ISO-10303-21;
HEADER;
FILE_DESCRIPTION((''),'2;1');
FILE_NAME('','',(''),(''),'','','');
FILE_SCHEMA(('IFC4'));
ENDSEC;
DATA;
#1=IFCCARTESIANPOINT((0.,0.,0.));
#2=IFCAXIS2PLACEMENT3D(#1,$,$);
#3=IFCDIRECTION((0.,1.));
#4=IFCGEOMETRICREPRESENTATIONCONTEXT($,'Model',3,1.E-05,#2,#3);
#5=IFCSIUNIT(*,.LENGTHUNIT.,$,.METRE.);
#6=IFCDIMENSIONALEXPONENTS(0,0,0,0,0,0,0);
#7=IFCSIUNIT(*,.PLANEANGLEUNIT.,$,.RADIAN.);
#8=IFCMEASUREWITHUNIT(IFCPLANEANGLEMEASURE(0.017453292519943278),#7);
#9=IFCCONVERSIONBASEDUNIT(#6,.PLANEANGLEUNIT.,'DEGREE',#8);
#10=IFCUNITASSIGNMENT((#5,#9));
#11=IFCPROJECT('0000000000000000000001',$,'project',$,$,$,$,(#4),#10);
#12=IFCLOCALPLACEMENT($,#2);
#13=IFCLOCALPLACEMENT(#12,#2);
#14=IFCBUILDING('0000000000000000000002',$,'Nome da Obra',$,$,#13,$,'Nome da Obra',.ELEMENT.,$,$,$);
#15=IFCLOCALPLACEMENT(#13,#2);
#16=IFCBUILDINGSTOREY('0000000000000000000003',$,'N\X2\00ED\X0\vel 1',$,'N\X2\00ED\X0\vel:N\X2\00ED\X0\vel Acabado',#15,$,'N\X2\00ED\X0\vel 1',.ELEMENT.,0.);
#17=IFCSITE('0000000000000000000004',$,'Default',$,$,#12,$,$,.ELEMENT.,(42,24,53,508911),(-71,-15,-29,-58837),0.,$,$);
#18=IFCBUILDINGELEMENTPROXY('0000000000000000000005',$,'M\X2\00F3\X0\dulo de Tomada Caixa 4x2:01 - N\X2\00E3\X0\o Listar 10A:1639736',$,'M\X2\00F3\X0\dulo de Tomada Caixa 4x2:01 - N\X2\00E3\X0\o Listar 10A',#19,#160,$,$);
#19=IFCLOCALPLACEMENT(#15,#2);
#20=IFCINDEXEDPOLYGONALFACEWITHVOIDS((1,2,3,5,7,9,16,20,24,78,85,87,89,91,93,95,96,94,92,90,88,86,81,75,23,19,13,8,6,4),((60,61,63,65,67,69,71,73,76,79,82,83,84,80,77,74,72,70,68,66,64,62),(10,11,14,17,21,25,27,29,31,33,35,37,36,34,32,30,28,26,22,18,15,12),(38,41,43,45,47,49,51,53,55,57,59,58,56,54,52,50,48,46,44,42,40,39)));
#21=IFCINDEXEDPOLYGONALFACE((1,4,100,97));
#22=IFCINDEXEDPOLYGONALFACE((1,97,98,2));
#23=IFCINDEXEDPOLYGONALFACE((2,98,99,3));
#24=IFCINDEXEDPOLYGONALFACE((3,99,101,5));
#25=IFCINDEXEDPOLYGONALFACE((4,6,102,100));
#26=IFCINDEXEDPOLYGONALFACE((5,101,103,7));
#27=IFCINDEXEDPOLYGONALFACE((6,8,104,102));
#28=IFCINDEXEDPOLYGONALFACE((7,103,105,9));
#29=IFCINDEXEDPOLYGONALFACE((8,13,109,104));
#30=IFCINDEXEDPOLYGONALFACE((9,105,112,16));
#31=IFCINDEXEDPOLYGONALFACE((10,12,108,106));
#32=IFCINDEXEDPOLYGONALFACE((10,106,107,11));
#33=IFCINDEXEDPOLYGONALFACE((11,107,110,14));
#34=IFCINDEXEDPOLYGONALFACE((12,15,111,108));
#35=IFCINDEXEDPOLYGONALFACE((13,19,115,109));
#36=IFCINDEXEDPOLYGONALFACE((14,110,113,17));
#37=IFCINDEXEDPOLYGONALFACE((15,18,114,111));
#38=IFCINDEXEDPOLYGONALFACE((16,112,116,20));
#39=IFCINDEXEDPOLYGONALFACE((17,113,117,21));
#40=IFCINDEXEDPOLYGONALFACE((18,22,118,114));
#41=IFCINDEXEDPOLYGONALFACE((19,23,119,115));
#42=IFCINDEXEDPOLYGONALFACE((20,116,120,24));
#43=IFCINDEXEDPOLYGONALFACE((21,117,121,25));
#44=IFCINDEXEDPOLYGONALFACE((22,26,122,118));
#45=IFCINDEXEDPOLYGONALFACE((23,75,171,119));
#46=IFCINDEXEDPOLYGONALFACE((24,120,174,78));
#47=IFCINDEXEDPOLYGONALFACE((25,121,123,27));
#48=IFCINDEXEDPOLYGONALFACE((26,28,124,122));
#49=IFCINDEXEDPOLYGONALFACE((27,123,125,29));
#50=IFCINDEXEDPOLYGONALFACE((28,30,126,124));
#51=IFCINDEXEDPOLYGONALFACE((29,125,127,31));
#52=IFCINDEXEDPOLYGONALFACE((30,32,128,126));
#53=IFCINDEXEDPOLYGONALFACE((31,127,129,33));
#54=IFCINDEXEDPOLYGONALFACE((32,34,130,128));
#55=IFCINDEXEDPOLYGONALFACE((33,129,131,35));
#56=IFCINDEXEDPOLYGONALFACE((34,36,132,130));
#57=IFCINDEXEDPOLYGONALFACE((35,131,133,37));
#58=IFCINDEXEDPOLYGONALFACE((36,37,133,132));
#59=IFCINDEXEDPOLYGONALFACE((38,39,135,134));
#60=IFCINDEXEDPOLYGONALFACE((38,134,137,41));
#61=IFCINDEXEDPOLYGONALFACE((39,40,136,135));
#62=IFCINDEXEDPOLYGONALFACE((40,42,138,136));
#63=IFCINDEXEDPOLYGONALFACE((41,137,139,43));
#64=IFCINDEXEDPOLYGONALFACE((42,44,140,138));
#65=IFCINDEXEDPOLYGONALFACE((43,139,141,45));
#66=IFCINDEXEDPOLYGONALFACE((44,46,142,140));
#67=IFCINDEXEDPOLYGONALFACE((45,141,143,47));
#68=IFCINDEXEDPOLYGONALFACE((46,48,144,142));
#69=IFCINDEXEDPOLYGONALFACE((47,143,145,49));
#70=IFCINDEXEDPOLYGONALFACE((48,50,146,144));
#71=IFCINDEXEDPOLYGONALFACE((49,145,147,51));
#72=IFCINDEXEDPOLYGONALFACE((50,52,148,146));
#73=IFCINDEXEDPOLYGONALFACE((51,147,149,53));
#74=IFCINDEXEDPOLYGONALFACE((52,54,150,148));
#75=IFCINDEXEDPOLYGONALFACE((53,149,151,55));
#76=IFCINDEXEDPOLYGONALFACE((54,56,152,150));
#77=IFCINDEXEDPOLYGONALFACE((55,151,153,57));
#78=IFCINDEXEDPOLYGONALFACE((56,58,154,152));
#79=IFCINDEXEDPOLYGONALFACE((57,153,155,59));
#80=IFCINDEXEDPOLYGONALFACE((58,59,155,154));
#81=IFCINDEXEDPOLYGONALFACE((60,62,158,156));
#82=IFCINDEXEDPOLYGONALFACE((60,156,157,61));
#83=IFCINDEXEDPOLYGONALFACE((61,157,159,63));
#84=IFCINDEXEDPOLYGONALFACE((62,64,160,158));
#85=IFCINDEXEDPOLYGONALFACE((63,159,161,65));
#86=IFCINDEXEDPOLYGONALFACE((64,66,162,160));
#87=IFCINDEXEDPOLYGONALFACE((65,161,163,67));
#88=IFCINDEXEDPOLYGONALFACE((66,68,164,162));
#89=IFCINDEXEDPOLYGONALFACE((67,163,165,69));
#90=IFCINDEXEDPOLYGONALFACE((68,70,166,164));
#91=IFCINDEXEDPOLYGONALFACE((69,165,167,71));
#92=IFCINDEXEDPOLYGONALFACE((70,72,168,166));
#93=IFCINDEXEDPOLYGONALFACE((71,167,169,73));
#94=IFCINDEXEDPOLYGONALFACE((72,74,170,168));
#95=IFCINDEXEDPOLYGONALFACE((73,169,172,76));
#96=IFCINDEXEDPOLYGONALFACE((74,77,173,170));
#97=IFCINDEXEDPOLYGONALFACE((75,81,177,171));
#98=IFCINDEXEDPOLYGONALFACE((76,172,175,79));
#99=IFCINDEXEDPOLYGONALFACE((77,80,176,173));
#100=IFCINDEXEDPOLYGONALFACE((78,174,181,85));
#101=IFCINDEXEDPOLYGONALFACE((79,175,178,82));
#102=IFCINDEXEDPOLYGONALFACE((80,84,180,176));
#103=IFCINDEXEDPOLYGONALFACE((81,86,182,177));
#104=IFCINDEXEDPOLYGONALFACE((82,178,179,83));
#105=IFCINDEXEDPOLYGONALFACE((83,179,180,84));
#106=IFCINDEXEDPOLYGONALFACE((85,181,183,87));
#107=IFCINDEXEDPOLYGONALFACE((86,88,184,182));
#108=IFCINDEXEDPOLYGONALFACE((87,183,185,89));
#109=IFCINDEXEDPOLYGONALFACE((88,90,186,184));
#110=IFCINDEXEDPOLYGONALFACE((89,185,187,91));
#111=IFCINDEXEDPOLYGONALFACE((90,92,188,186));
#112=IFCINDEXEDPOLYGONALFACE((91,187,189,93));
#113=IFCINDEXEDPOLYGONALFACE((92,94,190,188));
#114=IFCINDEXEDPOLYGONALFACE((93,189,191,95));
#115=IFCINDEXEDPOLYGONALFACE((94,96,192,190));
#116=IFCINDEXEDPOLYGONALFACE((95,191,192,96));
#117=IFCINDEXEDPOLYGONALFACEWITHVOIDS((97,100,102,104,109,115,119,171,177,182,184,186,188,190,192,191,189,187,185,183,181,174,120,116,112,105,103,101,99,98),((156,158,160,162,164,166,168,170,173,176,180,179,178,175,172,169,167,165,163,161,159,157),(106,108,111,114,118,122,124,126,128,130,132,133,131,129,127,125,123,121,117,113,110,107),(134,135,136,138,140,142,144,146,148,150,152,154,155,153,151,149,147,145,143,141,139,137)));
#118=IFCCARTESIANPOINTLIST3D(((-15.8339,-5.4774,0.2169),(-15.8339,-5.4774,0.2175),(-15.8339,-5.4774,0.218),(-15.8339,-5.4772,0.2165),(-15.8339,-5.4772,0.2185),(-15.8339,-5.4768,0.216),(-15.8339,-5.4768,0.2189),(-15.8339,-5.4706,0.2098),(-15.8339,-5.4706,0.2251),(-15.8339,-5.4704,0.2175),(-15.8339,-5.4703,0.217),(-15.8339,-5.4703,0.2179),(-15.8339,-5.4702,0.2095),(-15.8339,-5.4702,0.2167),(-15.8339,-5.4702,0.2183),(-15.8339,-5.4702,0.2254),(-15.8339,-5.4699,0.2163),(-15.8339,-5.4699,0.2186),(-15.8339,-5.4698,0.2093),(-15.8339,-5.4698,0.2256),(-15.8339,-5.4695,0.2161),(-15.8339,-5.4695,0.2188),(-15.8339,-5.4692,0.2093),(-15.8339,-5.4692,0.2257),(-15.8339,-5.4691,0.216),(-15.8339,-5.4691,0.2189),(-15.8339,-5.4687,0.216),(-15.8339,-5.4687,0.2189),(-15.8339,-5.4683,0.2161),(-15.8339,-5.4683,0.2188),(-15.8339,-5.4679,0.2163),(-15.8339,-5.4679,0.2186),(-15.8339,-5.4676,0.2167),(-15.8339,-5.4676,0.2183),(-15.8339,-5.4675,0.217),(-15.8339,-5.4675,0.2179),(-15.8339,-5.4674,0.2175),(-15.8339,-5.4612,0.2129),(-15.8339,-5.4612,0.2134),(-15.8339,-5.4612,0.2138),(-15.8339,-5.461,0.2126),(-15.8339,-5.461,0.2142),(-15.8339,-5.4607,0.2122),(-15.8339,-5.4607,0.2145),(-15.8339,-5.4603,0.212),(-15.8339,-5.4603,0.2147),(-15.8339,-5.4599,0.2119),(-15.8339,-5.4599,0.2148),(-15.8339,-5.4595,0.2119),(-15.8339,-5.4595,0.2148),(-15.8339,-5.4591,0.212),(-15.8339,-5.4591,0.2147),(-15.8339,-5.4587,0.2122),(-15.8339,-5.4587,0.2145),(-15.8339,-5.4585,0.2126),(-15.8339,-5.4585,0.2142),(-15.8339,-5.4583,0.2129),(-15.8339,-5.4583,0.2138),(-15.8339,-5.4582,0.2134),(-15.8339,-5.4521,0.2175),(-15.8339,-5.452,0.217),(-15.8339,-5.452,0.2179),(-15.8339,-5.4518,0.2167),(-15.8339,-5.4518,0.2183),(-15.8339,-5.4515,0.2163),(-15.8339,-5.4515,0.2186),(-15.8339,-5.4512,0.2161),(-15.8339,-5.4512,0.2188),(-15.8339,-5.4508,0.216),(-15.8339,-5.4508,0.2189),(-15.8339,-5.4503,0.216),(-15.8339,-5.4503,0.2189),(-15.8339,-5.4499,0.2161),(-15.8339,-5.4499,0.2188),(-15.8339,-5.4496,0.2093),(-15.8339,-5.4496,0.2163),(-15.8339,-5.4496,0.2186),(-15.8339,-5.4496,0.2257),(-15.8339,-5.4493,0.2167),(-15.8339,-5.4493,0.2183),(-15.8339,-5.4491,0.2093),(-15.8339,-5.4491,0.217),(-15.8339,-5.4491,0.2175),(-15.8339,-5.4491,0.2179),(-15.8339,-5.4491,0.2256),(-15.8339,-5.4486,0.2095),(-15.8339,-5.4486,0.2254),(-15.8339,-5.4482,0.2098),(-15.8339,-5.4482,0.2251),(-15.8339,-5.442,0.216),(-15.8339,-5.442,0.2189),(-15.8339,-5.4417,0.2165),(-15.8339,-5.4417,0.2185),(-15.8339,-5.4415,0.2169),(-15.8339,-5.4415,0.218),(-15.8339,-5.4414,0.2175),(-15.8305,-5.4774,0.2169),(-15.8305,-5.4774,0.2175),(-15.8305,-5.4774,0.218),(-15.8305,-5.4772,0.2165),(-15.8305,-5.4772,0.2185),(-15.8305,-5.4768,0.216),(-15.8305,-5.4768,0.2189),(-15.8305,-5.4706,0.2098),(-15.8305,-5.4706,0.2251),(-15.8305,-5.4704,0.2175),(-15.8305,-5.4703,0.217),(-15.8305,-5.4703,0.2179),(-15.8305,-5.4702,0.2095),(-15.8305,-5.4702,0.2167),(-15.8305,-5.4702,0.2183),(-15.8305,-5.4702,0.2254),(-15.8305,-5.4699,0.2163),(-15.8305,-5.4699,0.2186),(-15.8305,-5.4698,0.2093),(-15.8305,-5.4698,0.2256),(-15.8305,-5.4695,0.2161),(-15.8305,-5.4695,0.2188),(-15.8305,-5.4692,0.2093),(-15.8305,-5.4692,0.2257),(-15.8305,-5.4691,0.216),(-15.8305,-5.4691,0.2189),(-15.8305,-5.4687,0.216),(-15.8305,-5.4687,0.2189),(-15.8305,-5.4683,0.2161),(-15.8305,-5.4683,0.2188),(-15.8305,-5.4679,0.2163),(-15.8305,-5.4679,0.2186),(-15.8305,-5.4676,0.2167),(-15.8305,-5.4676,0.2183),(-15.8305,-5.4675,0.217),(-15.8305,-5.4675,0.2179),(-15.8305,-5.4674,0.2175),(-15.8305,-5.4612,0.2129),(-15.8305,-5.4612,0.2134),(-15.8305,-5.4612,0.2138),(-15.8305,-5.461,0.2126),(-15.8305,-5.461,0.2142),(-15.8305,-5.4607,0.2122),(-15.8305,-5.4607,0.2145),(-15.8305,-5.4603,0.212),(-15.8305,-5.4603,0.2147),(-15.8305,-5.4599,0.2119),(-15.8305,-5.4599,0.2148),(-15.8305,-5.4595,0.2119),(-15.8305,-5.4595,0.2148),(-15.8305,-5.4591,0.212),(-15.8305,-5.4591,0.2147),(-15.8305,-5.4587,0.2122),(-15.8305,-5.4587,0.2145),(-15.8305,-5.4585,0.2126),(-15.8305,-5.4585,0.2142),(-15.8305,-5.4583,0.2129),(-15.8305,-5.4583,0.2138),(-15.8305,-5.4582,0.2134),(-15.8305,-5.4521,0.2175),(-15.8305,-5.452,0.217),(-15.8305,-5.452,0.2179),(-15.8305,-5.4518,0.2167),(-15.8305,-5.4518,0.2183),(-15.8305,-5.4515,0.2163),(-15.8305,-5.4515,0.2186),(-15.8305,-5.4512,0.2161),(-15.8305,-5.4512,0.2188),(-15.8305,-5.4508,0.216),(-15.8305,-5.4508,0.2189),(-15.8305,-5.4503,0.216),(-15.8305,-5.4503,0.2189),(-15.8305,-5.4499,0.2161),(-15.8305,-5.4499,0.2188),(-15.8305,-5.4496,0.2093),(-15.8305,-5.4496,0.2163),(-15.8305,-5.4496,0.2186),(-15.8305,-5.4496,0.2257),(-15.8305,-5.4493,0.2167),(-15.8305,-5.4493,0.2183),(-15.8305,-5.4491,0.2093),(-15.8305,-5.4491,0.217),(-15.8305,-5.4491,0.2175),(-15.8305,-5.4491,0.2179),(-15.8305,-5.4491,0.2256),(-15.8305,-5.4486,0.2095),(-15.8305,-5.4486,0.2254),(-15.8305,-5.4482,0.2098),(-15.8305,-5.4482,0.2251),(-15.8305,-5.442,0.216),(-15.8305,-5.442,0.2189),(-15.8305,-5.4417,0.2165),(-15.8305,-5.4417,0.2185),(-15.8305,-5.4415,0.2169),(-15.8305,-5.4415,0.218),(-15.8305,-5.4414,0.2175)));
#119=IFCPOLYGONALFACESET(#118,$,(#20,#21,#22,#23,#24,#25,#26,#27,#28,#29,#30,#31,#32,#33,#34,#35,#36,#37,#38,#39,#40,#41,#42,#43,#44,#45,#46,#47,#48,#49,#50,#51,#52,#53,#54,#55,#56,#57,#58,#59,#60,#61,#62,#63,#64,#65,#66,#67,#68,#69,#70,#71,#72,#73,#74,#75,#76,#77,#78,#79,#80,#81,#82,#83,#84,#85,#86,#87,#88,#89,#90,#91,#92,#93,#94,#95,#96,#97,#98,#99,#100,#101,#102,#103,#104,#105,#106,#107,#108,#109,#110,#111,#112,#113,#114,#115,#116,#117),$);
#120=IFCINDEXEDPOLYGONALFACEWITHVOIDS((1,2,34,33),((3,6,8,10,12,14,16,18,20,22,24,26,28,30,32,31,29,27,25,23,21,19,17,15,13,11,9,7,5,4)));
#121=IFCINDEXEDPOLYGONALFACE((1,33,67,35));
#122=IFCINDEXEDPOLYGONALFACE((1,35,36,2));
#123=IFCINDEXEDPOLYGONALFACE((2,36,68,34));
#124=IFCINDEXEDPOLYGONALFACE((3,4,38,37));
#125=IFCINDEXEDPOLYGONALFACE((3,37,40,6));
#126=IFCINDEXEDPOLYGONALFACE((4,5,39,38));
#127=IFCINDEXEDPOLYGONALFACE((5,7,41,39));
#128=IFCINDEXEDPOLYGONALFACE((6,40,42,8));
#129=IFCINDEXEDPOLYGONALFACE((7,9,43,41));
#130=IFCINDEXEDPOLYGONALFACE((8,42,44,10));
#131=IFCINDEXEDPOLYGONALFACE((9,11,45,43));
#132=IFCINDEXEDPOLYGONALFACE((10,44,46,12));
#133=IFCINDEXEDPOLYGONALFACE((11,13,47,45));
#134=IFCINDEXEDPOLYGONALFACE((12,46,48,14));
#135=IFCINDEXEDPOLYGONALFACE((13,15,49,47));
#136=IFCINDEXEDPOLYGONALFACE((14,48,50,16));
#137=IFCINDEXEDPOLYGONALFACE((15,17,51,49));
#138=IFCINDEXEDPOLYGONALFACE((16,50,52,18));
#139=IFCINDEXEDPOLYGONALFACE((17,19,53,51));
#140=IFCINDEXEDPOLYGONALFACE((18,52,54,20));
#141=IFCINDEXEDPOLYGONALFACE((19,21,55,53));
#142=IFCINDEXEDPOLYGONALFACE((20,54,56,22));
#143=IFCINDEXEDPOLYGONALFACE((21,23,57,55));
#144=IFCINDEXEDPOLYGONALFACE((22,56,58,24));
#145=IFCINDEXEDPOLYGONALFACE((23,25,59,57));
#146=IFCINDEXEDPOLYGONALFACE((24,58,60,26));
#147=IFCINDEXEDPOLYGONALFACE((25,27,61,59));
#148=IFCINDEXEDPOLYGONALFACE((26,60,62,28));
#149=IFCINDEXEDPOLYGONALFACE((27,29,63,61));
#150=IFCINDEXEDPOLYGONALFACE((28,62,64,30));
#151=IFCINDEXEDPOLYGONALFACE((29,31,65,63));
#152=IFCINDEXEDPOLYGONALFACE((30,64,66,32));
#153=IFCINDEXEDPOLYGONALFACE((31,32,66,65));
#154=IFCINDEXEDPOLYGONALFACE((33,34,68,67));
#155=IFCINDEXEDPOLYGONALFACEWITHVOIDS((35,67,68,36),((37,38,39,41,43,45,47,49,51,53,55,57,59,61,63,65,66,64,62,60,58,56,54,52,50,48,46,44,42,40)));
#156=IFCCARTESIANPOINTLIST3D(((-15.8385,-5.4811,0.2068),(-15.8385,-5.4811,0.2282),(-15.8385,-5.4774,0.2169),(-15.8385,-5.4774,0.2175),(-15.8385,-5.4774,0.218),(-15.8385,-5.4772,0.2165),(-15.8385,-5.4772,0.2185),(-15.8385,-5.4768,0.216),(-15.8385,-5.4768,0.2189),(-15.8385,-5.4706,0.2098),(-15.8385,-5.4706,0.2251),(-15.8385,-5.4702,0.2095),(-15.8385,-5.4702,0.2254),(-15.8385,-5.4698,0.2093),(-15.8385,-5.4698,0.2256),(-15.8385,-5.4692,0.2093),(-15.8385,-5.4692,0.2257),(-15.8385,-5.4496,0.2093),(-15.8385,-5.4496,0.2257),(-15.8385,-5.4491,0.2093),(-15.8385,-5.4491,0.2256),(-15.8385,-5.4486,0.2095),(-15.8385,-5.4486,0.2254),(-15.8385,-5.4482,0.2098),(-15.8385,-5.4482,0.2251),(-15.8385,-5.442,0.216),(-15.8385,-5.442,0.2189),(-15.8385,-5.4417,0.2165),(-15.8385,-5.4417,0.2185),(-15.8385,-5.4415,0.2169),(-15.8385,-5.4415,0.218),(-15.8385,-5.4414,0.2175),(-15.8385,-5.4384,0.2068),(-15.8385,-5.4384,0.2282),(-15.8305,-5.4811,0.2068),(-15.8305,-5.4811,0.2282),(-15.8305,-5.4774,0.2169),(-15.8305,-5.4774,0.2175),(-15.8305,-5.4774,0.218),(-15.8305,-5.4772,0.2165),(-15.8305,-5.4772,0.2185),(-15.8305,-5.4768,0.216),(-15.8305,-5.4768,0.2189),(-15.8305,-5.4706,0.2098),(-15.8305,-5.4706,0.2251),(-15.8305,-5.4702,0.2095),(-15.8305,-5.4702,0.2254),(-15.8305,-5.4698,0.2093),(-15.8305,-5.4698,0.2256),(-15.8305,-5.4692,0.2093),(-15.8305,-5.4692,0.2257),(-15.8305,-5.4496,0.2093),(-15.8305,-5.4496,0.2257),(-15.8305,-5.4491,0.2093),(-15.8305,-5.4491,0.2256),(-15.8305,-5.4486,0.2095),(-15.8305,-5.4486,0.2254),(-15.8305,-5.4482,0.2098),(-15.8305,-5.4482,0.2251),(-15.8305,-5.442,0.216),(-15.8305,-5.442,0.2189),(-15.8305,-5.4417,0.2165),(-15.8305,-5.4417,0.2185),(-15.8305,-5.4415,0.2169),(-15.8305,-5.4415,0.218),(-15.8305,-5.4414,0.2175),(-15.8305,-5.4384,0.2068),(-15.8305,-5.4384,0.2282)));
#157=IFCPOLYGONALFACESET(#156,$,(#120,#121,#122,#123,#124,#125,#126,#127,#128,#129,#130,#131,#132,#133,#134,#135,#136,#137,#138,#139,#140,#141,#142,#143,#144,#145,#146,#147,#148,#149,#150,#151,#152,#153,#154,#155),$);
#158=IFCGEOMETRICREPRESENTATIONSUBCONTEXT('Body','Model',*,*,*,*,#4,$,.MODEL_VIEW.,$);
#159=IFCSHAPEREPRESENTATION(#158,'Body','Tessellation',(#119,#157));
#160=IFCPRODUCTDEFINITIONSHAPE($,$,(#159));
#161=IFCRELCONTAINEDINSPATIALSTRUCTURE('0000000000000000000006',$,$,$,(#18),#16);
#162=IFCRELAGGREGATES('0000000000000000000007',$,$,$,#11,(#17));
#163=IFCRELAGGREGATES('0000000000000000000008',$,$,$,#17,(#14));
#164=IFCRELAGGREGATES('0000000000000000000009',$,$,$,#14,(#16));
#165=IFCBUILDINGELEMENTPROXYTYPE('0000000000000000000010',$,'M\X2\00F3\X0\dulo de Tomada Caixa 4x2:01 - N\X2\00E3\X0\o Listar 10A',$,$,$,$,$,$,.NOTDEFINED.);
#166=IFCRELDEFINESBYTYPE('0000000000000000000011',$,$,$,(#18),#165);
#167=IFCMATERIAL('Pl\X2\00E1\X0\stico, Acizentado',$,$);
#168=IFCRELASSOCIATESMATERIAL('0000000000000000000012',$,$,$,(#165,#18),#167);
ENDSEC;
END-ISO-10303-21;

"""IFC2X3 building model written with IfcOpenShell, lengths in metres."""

from ifc_helpers import new_model, entity, si_unit, converted_unit, direction, frame, frame_2d, origin, place, context, subcontext, project, spatial, polyline, circle_curve, parameter, trimmed, segment, composite_curve, outline, extrude, source, transform, mapped, material, type_object, type_shapes, element, save


model = new_model("IFC2X3")

# Units and contexts
model_context = context("Model", 3, precision=1e-05, world=origin(), true_north=direction((0.0, 1.0)))
body_context = subcontext(model_context, "Body", "Model", "MODEL_VIEW")
ifc_project = project(units=[si_unit("LENGTHUNIT", "METRE"), converted_unit("PLANEANGLEUNIT", "DEGREE", entity("IfcPlaneAngleMeasure", 0.017453292519943278), si_unit("PLANEANGLEUNIT", "RADIAN"), dimensions=[0, 0, 0, 0, 0, 0, 0])], contexts=[model_context])

# Site, building, storey
site_placement = place(None, origin())
site = spatial("IfcSite", under=ifc_project, at=site_placement, Name="Default", CompositionType="ELEMENT", RefLatitude=(42, 24, 53, 508911), RefLongitude=(-71, -15, -29, -58837), RefElevation=0.0)
building_placement = place(site_placement, origin())
building = spatial("IfcBuilding", under=site, at=building_placement, Name="Nome da Obra", LongName="Nome da Obra", CompositionType="ELEMENT")
storey_placement = place(building_placement, origin())
storey = spatial("IfcBuildingStorey", under=building, at=storey_placement, Name="Nível 1", ObjectType="Nível:Nível Acabado", LongName="Nível 1", CompositionType="ELEMENT", Elevation=0.0)

# Building element proxy
ifc_material_1 = material(Name="Plástico, Acizentado")
building_element_proxy_type_1 = type_object("IfcBuildingElementProxyType", Name="Módulo de Tomada Caixa 4x2:01 - Não Listar 10A", PredefinedType="NOTDEFINED", material=ifc_material_1)
shared_shape_1 = source(origin(), body_context, "Body", "SweptSolid", [
    extrude(outline(composite_curve([segment(polyline([(-0.0098, -0.0082), (0.0098, -0.0082)]), True, "CONTINUOUS"), segment(trimmed(circle_curve(frame_2d((0.0098, -0.0062), x_axis=(1.0, 0.0)), 0.002), [parameter(270.0)], [parameter(315.0)], True, "PARAMETER"), True, "CONTINUOUS"), segment(polyline([(0.0112, -0.0076), (0.0174, -0.0014)]), True, "CONTINUOUS"), segment(trimmed(circle_curve(frame_2d((0.016, 0.0), x_axis=(1.0, 0.0)), 0.002), [parameter(315.0)], [parameter(45.0)], True, "PARAMETER"), True, "CONTINUOUS"), segment(polyline([(0.0174, 0.0014), (0.0112, 0.0076)]), True, "CONTINUOUS"), segment(trimmed(circle_curve(frame_2d((0.0098, 0.0062), x_axis=(1.0, 0.0)), 0.002), [parameter(45.0)], [parameter(90.0)], True, "PARAMETER"), True, "CONTINUOUS"), segment(polyline([(0.0098, 0.0082), (-0.0098, 0.0082)]), True, "CONTINUOUS"), segment(trimmed(circle_curve(frame_2d((-0.0098, 0.0062), x_axis=(1.0, 0.0)), 0.002), [parameter(90.0)], [parameter(135.0)], True, "PARAMETER"), True, "CONTINUOUS"), segment(polyline([(-0.0112, 0.0076), (-0.0174, 0.0014)]), True, "CONTINUOUS"), segment(trimmed(circle_curve(frame_2d((-0.016, 0.0), x_axis=(1.0, 0.0)), 0.002), [parameter(135.0)], [parameter(225.0)], True, "PARAMETER"), True, "CONTINUOUS"), segment(polyline([(-0.0174, -0.0014), (-0.0112, -0.0076)]), True, "CONTINUOUS"), segment(trimmed(circle_curve(frame_2d((-0.0098, -0.0062), x_axis=(1.0, 0.0)), 0.002), [parameter(225.0)], [parameter(270.0)], True, "PARAMETER"), True, "CONTINUOUS")], self_intersect=False), holes=[composite_curve([segment(trimmed(circle_curve(frame_2d((0.0089, 0.0), x_axis=(1.0, 0.0)), 0.0015), [parameter(0.0)], [parameter(180.0)], True, "PARAMETER"), False, "CONTINUOUS"), segment(trimmed(circle_curve(frame_2d((0.0089, 0.0), x_axis=(1.0, 0.0)), 0.0015), [parameter(180.0)], [parameter(0.0)], True, "PARAMETER"), False, "CONTINUOUS")], self_intersect=False), composite_curve([segment(trimmed(circle_curve(frame_2d((-0.0003, 0.0041), x_axis=(1.0, 0.0)), 0.0015), [parameter(0.0)], [parameter(180.0)], True, "PARAMETER"), False, "CONTINUOUS"), segment(trimmed(circle_curve(frame_2d((-0.0003, 0.0041), x_axis=(1.0, 0.0)), 0.0015), [parameter(180.0)], [parameter(0.0)], True, "PARAMETER"), False, "CONTINUOUS")], self_intersect=False), composite_curve([segment(trimmed(circle_curve(frame_2d((-0.0095, 0.0), x_axis=(1.0, 0.0)), 0.0015), [parameter(0.0)], [parameter(180.0)], True, "PARAMETER"), False, "CONTINUOUS"), segment(trimmed(circle_curve(frame_2d((-0.0095, 0.0), x_axis=(1.0, 0.0)), 0.0015), [parameter(180.0)], [parameter(0.0)], True, "PARAMETER"), False, "CONTINUOUS")], self_intersect=False)]), frame((0.0003, 0.0, 0.125), z_axis=(0.0, 1.0, 0.0), x_axis=(1.0, 0.0, 0.0)), (0.0, 0.0, 1.0), 0.0034),
    extrude(outline(polyline([(-0.0214, -0.0107), (0.0214, -0.0107), (0.0214, 0.0107), (-0.0214, 0.0107), (-0.0214, -0.0107)]), holes=[composite_curve([segment(polyline([(0.0101, -0.0082), (-0.0095, -0.0082)]), True, "CONTINUOUS"), segment(trimmed(circle_curve(frame_2d((-0.0095, -0.0062), x_axis=(1.0, 0.0)), 0.002), [parameter(225.0)], [parameter(270.0)], True, "PARAMETER"), False, "CONTINUOUS"), segment(polyline([(-0.0109, -0.0076), (-0.0171, -0.0014)]), True, "CONTINUOUS"), segment(trimmed(circle_curve(frame_2d((-0.0157, 0.0), x_axis=(1.0, 0.0)), 0.002), [parameter(135.0)], [parameter(225.0)], True, "PARAMETER"), False, "CONTINUOUS"), segment(polyline([(-0.0171, 0.0014), (-0.0109, 0.0076)]), True, "CONTINUOUS"), segment(trimmed(circle_curve(frame_2d((-0.0095, 0.0062), x_axis=(1.0, 0.0)), 0.002), [parameter(90.0)], [parameter(135.0)], True, "PARAMETER"), False, "CONTINUOUS"), segment(polyline([(-0.0095, 0.0082), (0.0101, 0.0082)]), True, "CONTINUOUS"), segment(trimmed(circle_curve(frame_2d((0.0101, 0.0062), x_axis=(1.0, 0.0)), 0.002), [parameter(45.0)], [parameter(90.0)], True, "PARAMETER"), False, "CONTINUOUS"), segment(polyline([(0.0115, 0.0076), (0.0177, 0.0014)]), True, "CONTINUOUS"), segment(trimmed(circle_curve(frame_2d((0.0163, 0.0), x_axis=(1.0, 0.0)), 0.002), [parameter(315.0)], [parameter(45.0)], True, "PARAMETER"), False, "CONTINUOUS"), segment(polyline([(0.0177, -0.0014), (0.0115, -0.0076)]), True, "CONTINUOUS"), segment(trimmed(circle_curve(frame_2d((0.0101, -0.0062), x_axis=(1.0, 0.0)), 0.002), [parameter(270.0)], [parameter(315.0)], True, "PARAMETER"), False, "CONTINUOUS")], self_intersect=False)]), frame((0.0, 0.0, 0.125), z_axis=(0.0, 1.0, 0.0), x_axis=(1.0, 0.0, 0.0)), (0.0, 0.0, 1.0), 0.008),
])
type_shapes(building_element_proxy_type_1, [shared_shape_1])
for number, where, z_axis, x_axis, name in (
    (1, (-15.8305, -5.4597, 0.0925), (0.0, 0.0, 1.0), (0.0, 1.0, 0.0), "Módulo de Tomada Caixa 4x2:01 - Não Listar 10A:1639736"),
):
    element("IfcBuildingElementProxy", number, at=place(storey_placement, frame(where, z_axis=z_axis, x_axis=x_axis)), inside=storey, type_object=building_element_proxy_type_1, material=ifc_material_1, Name=name, ObjectType="Módulo de Tomada Caixa 4x2:01 - Não Listar 10A", context=body_context, shape_type="MappedRepresentation", body=[
        mapped(shared_shape_1, transform((0.0, 0.0, 0.0), scale=1.0)),
    ])

save(model, "model.ifc")
